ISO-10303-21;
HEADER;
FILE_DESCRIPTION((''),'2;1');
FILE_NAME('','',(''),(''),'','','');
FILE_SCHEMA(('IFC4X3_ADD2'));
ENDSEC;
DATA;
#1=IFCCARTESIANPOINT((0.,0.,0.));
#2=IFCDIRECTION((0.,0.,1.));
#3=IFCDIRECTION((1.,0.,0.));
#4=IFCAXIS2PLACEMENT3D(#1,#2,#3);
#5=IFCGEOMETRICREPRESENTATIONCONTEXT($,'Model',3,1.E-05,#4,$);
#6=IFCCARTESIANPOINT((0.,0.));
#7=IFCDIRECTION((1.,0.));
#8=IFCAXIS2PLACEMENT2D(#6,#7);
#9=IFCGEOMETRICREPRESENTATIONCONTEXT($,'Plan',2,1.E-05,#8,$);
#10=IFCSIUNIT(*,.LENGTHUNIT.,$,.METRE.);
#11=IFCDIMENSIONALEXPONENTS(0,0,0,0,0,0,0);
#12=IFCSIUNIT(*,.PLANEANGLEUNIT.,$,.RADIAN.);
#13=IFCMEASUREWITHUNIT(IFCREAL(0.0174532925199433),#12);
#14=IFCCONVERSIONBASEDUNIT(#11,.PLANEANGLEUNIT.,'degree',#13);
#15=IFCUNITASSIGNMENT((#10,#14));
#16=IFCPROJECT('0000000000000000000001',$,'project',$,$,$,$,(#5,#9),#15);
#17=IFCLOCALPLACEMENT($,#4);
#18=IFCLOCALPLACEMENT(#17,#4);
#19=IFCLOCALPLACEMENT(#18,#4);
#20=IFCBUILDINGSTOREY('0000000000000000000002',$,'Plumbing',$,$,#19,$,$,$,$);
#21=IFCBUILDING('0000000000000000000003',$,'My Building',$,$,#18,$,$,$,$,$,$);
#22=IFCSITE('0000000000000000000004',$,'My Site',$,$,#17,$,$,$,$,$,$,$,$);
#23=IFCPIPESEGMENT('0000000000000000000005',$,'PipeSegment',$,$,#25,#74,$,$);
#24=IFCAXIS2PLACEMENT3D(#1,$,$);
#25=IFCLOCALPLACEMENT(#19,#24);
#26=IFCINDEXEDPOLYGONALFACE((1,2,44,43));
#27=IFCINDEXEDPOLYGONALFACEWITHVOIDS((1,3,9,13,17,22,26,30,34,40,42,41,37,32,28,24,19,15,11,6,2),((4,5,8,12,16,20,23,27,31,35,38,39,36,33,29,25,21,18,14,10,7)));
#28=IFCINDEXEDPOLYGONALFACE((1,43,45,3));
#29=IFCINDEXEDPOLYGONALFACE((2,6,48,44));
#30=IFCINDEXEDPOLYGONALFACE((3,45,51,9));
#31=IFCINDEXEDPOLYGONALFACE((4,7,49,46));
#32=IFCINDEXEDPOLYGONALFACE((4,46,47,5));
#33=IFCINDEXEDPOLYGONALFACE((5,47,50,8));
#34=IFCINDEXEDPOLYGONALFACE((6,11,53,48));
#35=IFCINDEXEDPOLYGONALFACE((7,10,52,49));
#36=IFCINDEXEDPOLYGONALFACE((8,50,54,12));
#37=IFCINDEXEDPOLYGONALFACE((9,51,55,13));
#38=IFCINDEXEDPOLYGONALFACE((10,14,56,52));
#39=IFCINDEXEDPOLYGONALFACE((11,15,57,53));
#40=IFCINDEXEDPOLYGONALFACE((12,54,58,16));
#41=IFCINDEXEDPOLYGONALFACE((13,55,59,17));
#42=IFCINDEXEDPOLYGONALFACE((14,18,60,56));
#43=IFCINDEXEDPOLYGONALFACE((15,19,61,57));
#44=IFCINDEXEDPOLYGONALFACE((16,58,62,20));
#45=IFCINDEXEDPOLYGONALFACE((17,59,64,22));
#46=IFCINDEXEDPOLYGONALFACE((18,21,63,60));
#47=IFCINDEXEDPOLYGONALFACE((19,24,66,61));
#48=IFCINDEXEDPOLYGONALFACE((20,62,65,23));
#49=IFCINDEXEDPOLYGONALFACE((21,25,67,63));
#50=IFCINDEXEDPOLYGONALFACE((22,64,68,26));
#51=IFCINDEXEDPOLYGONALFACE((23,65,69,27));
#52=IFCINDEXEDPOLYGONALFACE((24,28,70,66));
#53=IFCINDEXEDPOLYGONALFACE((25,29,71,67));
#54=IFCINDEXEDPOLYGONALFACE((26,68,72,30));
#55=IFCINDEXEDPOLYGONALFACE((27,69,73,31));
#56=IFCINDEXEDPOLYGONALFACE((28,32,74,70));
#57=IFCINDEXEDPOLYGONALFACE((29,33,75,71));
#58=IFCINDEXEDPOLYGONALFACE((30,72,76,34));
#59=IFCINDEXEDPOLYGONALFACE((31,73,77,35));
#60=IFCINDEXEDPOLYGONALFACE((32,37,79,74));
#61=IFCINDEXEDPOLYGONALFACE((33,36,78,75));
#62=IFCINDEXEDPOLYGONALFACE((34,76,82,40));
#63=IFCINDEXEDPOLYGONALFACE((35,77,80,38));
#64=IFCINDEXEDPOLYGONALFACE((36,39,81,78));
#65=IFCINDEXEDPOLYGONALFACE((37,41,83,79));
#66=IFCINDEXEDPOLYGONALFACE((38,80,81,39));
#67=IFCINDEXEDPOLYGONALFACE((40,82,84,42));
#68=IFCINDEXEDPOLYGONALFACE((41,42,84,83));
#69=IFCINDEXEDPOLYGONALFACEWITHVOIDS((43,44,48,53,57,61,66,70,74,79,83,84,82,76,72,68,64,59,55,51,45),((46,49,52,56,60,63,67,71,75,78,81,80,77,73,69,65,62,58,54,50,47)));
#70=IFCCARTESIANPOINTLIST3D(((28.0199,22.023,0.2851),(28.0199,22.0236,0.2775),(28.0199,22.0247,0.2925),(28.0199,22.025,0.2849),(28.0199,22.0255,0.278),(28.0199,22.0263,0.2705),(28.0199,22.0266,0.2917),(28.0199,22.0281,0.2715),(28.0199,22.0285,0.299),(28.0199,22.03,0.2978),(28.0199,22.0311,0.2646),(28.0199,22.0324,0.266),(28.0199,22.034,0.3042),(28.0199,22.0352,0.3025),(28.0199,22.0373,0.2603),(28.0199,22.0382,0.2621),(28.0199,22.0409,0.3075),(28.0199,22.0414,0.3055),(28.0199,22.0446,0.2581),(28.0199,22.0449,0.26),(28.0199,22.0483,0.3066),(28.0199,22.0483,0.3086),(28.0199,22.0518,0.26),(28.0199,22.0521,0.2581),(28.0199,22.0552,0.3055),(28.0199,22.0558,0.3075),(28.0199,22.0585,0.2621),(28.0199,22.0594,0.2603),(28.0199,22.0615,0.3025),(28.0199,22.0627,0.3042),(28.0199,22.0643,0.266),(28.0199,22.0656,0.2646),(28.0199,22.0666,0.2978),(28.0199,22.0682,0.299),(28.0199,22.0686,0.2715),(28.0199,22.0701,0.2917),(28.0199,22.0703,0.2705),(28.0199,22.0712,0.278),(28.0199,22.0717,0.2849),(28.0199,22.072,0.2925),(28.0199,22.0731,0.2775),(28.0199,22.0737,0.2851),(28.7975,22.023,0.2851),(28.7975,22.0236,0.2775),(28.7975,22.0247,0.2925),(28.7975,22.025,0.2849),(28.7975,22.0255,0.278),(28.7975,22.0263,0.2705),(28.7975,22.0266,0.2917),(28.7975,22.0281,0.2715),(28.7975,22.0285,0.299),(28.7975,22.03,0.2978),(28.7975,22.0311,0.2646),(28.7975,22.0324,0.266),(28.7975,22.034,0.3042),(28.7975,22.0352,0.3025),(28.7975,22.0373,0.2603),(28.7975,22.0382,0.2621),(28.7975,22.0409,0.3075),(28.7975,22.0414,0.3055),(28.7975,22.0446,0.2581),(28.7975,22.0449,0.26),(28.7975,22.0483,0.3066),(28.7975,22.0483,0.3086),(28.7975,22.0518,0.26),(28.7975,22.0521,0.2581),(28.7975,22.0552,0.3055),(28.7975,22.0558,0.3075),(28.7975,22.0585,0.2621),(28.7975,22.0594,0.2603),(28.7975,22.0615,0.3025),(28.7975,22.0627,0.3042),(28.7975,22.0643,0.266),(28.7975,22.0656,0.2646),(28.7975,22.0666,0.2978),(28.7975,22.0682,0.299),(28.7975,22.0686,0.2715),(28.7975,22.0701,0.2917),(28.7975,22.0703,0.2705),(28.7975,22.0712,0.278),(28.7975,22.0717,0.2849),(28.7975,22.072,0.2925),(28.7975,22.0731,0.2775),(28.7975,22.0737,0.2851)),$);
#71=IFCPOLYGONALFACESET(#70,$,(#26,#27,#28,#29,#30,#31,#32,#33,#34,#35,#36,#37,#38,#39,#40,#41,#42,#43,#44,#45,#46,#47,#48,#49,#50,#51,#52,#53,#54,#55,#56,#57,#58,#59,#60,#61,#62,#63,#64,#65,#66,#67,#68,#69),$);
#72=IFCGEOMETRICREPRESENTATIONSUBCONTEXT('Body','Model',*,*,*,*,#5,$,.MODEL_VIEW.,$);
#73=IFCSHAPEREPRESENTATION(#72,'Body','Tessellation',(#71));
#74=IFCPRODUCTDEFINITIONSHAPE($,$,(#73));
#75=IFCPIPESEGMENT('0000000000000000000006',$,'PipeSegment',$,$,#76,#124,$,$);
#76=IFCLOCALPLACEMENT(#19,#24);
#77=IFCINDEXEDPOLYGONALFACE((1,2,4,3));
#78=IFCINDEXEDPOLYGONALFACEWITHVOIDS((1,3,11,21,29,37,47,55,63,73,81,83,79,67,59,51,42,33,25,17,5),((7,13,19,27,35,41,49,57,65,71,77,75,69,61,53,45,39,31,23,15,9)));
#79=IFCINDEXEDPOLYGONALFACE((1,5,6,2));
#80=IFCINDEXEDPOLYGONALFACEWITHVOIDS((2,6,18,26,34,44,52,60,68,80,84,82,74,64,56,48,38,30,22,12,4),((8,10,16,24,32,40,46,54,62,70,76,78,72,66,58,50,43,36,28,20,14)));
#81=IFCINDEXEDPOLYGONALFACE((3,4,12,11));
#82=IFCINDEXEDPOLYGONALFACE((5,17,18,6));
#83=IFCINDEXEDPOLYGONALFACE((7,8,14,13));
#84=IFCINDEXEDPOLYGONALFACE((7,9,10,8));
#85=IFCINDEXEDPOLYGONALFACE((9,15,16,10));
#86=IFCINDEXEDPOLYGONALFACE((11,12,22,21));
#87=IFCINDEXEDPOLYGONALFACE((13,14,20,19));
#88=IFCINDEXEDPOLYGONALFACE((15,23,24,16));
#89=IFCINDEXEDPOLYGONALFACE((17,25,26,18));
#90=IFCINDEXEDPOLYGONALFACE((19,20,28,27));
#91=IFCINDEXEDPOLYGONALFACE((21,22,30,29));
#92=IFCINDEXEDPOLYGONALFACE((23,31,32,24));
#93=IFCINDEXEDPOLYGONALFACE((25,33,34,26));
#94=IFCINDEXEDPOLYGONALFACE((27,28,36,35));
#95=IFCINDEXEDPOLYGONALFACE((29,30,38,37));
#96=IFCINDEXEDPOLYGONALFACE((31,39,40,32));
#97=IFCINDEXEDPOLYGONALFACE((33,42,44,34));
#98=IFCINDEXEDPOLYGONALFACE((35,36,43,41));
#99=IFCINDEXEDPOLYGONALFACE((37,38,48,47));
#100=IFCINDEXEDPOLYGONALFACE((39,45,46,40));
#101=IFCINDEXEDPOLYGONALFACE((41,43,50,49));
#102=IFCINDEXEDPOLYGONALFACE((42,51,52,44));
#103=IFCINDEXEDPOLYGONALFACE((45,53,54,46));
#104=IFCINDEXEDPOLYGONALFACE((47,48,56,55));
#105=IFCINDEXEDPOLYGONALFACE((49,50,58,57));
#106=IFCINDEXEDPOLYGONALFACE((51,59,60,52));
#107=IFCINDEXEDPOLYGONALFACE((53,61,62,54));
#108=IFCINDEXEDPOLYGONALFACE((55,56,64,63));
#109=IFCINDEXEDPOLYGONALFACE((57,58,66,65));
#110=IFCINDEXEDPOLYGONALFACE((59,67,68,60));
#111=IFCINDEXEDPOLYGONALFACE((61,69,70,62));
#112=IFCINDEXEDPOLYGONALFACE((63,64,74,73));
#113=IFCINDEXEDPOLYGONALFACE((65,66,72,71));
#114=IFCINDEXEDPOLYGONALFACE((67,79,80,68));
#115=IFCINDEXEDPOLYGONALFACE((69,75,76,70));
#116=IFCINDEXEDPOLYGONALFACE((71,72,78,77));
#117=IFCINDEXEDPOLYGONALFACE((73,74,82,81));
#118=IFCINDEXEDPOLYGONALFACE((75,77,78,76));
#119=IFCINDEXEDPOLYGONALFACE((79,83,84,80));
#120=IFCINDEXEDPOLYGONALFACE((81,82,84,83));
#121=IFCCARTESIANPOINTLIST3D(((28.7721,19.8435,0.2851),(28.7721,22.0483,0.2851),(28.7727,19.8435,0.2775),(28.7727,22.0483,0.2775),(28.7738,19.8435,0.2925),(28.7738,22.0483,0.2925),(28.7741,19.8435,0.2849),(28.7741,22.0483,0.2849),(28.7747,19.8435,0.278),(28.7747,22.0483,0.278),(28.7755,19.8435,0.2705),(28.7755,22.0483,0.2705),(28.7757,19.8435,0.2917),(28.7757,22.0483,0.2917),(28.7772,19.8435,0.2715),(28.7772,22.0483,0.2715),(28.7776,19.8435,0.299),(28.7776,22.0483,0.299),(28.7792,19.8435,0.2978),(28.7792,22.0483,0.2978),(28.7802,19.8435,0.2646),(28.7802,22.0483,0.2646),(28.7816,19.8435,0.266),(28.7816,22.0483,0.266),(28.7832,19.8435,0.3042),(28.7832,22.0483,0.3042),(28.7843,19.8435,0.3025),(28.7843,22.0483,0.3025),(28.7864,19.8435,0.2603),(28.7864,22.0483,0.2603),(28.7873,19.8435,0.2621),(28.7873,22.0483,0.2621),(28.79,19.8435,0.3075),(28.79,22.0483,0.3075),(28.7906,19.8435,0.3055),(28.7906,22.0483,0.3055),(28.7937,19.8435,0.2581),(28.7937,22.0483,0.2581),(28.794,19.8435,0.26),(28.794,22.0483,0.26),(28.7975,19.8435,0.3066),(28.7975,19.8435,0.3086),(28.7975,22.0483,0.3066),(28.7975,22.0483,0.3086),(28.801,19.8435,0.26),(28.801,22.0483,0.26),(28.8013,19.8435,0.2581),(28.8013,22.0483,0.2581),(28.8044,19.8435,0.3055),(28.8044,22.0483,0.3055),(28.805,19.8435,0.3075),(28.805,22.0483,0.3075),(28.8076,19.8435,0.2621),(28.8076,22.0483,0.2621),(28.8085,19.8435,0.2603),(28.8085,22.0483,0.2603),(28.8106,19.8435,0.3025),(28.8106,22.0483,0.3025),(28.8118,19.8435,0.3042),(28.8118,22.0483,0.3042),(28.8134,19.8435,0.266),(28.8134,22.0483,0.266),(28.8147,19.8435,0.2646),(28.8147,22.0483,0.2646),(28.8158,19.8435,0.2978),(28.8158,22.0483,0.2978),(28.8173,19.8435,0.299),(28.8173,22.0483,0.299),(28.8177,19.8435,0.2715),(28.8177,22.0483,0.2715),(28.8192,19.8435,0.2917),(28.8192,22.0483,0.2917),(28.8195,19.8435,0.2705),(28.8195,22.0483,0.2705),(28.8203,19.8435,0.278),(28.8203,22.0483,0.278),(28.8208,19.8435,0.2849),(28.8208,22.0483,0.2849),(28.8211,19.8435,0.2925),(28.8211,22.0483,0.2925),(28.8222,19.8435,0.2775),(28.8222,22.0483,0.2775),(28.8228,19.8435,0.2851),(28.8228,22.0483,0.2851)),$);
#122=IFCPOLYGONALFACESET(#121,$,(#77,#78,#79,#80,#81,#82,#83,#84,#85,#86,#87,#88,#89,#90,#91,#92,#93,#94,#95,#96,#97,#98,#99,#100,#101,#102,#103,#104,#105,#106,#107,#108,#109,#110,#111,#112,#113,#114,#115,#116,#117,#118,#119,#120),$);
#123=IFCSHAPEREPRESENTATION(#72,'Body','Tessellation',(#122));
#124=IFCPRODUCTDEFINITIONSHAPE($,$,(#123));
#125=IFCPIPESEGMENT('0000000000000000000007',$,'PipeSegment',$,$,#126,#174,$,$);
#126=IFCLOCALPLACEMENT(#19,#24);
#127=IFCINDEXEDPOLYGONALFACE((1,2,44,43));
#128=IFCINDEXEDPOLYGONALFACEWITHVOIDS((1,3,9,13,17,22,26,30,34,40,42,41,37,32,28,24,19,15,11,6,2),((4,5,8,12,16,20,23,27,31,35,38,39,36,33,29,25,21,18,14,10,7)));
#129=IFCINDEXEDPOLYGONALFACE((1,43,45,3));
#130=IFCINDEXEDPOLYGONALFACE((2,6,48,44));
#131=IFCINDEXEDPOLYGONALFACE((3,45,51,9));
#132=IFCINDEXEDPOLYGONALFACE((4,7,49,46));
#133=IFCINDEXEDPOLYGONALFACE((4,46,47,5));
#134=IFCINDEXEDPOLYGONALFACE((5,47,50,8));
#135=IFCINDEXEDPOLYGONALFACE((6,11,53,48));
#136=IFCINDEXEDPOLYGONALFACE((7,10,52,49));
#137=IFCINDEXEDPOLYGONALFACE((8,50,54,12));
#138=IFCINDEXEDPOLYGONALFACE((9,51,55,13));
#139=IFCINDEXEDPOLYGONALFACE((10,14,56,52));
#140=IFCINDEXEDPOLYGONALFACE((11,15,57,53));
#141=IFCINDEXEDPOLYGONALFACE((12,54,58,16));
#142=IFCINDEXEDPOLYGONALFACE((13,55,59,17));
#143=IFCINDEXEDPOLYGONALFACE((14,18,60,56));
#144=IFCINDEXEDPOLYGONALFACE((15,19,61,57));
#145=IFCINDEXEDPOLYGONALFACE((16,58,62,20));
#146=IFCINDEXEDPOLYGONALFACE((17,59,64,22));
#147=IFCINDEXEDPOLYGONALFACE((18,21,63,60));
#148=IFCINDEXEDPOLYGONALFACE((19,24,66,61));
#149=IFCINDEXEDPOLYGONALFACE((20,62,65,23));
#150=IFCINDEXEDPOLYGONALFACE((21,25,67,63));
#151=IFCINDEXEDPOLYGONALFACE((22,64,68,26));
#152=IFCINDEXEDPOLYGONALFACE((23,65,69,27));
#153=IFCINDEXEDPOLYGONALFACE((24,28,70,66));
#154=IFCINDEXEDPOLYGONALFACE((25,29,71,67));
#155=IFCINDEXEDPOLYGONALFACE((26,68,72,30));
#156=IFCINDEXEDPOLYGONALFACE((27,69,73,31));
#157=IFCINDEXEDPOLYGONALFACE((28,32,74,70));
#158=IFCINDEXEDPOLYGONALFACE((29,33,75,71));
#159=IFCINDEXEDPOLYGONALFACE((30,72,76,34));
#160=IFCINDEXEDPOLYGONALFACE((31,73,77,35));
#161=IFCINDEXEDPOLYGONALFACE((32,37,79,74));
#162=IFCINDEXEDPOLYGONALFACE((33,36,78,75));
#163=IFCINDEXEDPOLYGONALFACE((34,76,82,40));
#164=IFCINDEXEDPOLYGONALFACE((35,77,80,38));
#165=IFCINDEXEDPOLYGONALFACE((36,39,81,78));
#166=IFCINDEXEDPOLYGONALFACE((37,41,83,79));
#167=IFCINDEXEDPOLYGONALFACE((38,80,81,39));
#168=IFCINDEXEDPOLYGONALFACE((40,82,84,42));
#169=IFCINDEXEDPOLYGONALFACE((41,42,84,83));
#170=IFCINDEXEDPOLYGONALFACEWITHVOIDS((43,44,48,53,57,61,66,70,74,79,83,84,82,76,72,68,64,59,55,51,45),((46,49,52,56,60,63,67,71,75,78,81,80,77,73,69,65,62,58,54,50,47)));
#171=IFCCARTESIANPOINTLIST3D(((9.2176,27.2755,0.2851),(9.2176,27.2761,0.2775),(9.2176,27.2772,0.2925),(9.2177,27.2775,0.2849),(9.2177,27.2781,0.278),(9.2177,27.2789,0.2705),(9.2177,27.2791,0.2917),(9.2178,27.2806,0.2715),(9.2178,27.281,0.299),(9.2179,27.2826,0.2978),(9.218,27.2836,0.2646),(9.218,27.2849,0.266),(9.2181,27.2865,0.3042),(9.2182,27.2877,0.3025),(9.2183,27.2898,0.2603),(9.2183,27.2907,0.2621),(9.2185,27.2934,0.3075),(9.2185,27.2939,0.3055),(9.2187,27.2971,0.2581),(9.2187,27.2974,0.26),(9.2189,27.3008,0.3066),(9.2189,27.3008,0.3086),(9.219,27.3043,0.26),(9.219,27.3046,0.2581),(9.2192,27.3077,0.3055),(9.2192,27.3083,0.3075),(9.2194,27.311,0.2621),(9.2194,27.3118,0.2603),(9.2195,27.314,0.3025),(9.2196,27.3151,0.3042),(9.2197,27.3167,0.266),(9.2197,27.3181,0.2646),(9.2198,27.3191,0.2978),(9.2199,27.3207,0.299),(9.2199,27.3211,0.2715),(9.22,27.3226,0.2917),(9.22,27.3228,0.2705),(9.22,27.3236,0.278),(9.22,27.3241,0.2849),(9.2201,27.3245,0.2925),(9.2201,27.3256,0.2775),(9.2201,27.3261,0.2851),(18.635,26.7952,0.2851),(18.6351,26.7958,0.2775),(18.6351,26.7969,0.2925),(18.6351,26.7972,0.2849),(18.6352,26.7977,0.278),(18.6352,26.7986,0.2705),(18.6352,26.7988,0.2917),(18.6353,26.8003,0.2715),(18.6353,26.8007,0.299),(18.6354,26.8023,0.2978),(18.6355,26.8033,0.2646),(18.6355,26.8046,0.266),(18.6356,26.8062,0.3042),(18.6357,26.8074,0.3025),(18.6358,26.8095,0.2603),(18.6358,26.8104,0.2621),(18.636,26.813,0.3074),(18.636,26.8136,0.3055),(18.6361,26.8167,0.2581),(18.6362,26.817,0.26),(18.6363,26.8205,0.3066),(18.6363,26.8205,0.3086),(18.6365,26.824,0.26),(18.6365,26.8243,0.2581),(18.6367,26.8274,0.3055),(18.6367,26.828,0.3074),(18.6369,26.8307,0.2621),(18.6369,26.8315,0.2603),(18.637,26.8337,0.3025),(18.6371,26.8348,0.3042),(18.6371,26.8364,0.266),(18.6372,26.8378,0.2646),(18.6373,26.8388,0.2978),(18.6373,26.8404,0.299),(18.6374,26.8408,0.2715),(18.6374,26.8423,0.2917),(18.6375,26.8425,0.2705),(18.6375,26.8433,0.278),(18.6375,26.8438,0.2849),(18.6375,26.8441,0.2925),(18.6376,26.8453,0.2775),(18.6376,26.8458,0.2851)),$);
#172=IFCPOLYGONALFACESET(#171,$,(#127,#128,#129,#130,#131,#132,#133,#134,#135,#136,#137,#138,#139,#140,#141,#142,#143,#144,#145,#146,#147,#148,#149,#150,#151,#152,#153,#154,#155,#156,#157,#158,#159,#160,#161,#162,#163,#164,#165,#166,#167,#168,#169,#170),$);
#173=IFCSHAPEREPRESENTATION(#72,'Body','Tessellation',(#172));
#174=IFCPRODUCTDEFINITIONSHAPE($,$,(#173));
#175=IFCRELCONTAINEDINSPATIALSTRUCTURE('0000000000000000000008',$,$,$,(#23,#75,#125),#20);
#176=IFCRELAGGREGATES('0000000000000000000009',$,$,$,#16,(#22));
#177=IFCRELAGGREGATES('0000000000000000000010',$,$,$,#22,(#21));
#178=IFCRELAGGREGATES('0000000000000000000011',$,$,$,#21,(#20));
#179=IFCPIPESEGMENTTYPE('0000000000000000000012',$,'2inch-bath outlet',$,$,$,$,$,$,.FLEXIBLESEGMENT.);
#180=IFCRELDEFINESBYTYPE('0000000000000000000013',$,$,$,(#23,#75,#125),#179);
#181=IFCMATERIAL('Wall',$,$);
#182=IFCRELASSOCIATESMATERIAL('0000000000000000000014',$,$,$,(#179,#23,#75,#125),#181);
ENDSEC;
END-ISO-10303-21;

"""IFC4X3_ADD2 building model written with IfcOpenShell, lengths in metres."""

from ifc_helpers import new_model, entity, si_unit, converted_unit, frame, origin_with_axes, origin_2d_with_axis, place, context, subcontext, project, spatial, hollow_circle, extrude, material, material_profile, profile_set, profile_usage, type_object, element, save


model = new_model("IFC4X3_ADD2")

# Units and contexts
model_context = context("Model", 3, precision=1e-05, world=origin_with_axes())
plan_context = context("Plan", 2, precision=1e-05, world=origin_2d_with_axis())
body_context = subcontext(model_context, "Body", "Model", "MODEL_VIEW")
ifc_project = project(units=[si_unit("LENGTHUNIT", "METRE"), converted_unit("PLANEANGLEUNIT", "degree", entity("IfcReal", 0.0174532925199433), si_unit("PLANEANGLEUNIT", "RADIAN"), dimensions=[0, 0, 0, 0, 0, 0, 0])], contexts=[model_context, plan_context])

# Site, building, storey
site_placement = place(None, origin_with_axes())
site = spatial("IfcSite", under=ifc_project, at=site_placement, Name="My Site")
building_placement = place(site_placement, origin_with_axes())
building = spatial("IfcBuilding", under=site, at=building_placement, Name="My Building")
storey_placement = place(building_placement, origin_with_axes())
storey = spatial("IfcBuildingStorey", under=building, at=storey_placement, Name="Plumbing")

# Pipe segments
ifc_material_1 = material(Name="Wall")
ifc_material_profile_1 = material_profile(ifc_material_1, hollow_circle(Radius=0.0254, WallThickness=0.002))
ifc_profile_set_1 = profile_set([ifc_material_profile_1], Name="graywater")
ifc_material_profile_2 = material_profile(ifc_material_1, hollow_circle(Radius=0.0254, WallThickness=0.002))
ifc_profile_set_2 = profile_set([ifc_material_profile_2], Name="graywater")
pipe_segment_type_1 = type_object("IfcPipeSegmentType", Name="2inch-bath outlet", PredefinedType="FLEXIBLESEGMENT", material=ifc_profile_set_2)
ifc_profile_usage_1 = profile_usage(ifc_profile_set_1)
pipe_segment_1_placement = place(storey_placement, frame((28.7975, 22.0483, 0.2832), z_axis=(-1.0, 0.0, 0.000001), x_axis=(0.000001, 0.0, 1.0)))
element("IfcPipeSegment", 1, at=pipe_segment_1_placement, inside=storey, type_object=pipe_segment_type_1, material=ifc_profile_usage_1, Name="PipeSegment", context=body_context, shape_type="SweptSolid", body=[
    extrude(hollow_circle(Radius=0.0254, WallThickness=0.002), origin_with_axes(), (0.0, 0.0, 1.0), 0.7776),
])
ifc_profile_usage_2 = profile_usage(ifc_profile_set_1)
pipe_segment_2_placement = place(storey_placement, frame((28.7975, 22.0483, 0.2832), z_axis=(0.0, -1.0, 0.0), x_axis=(0.000001, 0.0, 1.0)))
element("IfcPipeSegment", 2, at=pipe_segment_2_placement, inside=storey, type_object=pipe_segment_type_1, material=ifc_profile_usage_2, Name="PipeSegment", context=body_context, shape_type="SweptSolid", body=[
    extrude(hollow_circle(Radius=0.0254, WallThickness=0.002), origin_with_axes(), (0.0, 0.0, 1.0), 2.2048),
])
ifc_profile_usage_3 = profile_usage(ifc_profile_set_1)
pipe_segment_3_placement = place(storey_placement, frame((9.2189, 27.3008, 0.2832), z_axis=(0.998702, -0.050936, -0.000001), x_axis=(0.000001, 0.0, 1.0)))
element("IfcPipeSegment", 3, at=pipe_segment_3_placement, inside=storey, type_object=pipe_segment_type_1, material=ifc_profile_usage_3, Name="PipeSegment", context=body_context, shape_type="SweptSolid", body=[
    extrude(hollow_circle(Radius=0.0254, WallThickness=0.002), origin_with_axes(), (0.0, 0.0, 1.0), 9.4297),
])

save(model, "model.ifc")
